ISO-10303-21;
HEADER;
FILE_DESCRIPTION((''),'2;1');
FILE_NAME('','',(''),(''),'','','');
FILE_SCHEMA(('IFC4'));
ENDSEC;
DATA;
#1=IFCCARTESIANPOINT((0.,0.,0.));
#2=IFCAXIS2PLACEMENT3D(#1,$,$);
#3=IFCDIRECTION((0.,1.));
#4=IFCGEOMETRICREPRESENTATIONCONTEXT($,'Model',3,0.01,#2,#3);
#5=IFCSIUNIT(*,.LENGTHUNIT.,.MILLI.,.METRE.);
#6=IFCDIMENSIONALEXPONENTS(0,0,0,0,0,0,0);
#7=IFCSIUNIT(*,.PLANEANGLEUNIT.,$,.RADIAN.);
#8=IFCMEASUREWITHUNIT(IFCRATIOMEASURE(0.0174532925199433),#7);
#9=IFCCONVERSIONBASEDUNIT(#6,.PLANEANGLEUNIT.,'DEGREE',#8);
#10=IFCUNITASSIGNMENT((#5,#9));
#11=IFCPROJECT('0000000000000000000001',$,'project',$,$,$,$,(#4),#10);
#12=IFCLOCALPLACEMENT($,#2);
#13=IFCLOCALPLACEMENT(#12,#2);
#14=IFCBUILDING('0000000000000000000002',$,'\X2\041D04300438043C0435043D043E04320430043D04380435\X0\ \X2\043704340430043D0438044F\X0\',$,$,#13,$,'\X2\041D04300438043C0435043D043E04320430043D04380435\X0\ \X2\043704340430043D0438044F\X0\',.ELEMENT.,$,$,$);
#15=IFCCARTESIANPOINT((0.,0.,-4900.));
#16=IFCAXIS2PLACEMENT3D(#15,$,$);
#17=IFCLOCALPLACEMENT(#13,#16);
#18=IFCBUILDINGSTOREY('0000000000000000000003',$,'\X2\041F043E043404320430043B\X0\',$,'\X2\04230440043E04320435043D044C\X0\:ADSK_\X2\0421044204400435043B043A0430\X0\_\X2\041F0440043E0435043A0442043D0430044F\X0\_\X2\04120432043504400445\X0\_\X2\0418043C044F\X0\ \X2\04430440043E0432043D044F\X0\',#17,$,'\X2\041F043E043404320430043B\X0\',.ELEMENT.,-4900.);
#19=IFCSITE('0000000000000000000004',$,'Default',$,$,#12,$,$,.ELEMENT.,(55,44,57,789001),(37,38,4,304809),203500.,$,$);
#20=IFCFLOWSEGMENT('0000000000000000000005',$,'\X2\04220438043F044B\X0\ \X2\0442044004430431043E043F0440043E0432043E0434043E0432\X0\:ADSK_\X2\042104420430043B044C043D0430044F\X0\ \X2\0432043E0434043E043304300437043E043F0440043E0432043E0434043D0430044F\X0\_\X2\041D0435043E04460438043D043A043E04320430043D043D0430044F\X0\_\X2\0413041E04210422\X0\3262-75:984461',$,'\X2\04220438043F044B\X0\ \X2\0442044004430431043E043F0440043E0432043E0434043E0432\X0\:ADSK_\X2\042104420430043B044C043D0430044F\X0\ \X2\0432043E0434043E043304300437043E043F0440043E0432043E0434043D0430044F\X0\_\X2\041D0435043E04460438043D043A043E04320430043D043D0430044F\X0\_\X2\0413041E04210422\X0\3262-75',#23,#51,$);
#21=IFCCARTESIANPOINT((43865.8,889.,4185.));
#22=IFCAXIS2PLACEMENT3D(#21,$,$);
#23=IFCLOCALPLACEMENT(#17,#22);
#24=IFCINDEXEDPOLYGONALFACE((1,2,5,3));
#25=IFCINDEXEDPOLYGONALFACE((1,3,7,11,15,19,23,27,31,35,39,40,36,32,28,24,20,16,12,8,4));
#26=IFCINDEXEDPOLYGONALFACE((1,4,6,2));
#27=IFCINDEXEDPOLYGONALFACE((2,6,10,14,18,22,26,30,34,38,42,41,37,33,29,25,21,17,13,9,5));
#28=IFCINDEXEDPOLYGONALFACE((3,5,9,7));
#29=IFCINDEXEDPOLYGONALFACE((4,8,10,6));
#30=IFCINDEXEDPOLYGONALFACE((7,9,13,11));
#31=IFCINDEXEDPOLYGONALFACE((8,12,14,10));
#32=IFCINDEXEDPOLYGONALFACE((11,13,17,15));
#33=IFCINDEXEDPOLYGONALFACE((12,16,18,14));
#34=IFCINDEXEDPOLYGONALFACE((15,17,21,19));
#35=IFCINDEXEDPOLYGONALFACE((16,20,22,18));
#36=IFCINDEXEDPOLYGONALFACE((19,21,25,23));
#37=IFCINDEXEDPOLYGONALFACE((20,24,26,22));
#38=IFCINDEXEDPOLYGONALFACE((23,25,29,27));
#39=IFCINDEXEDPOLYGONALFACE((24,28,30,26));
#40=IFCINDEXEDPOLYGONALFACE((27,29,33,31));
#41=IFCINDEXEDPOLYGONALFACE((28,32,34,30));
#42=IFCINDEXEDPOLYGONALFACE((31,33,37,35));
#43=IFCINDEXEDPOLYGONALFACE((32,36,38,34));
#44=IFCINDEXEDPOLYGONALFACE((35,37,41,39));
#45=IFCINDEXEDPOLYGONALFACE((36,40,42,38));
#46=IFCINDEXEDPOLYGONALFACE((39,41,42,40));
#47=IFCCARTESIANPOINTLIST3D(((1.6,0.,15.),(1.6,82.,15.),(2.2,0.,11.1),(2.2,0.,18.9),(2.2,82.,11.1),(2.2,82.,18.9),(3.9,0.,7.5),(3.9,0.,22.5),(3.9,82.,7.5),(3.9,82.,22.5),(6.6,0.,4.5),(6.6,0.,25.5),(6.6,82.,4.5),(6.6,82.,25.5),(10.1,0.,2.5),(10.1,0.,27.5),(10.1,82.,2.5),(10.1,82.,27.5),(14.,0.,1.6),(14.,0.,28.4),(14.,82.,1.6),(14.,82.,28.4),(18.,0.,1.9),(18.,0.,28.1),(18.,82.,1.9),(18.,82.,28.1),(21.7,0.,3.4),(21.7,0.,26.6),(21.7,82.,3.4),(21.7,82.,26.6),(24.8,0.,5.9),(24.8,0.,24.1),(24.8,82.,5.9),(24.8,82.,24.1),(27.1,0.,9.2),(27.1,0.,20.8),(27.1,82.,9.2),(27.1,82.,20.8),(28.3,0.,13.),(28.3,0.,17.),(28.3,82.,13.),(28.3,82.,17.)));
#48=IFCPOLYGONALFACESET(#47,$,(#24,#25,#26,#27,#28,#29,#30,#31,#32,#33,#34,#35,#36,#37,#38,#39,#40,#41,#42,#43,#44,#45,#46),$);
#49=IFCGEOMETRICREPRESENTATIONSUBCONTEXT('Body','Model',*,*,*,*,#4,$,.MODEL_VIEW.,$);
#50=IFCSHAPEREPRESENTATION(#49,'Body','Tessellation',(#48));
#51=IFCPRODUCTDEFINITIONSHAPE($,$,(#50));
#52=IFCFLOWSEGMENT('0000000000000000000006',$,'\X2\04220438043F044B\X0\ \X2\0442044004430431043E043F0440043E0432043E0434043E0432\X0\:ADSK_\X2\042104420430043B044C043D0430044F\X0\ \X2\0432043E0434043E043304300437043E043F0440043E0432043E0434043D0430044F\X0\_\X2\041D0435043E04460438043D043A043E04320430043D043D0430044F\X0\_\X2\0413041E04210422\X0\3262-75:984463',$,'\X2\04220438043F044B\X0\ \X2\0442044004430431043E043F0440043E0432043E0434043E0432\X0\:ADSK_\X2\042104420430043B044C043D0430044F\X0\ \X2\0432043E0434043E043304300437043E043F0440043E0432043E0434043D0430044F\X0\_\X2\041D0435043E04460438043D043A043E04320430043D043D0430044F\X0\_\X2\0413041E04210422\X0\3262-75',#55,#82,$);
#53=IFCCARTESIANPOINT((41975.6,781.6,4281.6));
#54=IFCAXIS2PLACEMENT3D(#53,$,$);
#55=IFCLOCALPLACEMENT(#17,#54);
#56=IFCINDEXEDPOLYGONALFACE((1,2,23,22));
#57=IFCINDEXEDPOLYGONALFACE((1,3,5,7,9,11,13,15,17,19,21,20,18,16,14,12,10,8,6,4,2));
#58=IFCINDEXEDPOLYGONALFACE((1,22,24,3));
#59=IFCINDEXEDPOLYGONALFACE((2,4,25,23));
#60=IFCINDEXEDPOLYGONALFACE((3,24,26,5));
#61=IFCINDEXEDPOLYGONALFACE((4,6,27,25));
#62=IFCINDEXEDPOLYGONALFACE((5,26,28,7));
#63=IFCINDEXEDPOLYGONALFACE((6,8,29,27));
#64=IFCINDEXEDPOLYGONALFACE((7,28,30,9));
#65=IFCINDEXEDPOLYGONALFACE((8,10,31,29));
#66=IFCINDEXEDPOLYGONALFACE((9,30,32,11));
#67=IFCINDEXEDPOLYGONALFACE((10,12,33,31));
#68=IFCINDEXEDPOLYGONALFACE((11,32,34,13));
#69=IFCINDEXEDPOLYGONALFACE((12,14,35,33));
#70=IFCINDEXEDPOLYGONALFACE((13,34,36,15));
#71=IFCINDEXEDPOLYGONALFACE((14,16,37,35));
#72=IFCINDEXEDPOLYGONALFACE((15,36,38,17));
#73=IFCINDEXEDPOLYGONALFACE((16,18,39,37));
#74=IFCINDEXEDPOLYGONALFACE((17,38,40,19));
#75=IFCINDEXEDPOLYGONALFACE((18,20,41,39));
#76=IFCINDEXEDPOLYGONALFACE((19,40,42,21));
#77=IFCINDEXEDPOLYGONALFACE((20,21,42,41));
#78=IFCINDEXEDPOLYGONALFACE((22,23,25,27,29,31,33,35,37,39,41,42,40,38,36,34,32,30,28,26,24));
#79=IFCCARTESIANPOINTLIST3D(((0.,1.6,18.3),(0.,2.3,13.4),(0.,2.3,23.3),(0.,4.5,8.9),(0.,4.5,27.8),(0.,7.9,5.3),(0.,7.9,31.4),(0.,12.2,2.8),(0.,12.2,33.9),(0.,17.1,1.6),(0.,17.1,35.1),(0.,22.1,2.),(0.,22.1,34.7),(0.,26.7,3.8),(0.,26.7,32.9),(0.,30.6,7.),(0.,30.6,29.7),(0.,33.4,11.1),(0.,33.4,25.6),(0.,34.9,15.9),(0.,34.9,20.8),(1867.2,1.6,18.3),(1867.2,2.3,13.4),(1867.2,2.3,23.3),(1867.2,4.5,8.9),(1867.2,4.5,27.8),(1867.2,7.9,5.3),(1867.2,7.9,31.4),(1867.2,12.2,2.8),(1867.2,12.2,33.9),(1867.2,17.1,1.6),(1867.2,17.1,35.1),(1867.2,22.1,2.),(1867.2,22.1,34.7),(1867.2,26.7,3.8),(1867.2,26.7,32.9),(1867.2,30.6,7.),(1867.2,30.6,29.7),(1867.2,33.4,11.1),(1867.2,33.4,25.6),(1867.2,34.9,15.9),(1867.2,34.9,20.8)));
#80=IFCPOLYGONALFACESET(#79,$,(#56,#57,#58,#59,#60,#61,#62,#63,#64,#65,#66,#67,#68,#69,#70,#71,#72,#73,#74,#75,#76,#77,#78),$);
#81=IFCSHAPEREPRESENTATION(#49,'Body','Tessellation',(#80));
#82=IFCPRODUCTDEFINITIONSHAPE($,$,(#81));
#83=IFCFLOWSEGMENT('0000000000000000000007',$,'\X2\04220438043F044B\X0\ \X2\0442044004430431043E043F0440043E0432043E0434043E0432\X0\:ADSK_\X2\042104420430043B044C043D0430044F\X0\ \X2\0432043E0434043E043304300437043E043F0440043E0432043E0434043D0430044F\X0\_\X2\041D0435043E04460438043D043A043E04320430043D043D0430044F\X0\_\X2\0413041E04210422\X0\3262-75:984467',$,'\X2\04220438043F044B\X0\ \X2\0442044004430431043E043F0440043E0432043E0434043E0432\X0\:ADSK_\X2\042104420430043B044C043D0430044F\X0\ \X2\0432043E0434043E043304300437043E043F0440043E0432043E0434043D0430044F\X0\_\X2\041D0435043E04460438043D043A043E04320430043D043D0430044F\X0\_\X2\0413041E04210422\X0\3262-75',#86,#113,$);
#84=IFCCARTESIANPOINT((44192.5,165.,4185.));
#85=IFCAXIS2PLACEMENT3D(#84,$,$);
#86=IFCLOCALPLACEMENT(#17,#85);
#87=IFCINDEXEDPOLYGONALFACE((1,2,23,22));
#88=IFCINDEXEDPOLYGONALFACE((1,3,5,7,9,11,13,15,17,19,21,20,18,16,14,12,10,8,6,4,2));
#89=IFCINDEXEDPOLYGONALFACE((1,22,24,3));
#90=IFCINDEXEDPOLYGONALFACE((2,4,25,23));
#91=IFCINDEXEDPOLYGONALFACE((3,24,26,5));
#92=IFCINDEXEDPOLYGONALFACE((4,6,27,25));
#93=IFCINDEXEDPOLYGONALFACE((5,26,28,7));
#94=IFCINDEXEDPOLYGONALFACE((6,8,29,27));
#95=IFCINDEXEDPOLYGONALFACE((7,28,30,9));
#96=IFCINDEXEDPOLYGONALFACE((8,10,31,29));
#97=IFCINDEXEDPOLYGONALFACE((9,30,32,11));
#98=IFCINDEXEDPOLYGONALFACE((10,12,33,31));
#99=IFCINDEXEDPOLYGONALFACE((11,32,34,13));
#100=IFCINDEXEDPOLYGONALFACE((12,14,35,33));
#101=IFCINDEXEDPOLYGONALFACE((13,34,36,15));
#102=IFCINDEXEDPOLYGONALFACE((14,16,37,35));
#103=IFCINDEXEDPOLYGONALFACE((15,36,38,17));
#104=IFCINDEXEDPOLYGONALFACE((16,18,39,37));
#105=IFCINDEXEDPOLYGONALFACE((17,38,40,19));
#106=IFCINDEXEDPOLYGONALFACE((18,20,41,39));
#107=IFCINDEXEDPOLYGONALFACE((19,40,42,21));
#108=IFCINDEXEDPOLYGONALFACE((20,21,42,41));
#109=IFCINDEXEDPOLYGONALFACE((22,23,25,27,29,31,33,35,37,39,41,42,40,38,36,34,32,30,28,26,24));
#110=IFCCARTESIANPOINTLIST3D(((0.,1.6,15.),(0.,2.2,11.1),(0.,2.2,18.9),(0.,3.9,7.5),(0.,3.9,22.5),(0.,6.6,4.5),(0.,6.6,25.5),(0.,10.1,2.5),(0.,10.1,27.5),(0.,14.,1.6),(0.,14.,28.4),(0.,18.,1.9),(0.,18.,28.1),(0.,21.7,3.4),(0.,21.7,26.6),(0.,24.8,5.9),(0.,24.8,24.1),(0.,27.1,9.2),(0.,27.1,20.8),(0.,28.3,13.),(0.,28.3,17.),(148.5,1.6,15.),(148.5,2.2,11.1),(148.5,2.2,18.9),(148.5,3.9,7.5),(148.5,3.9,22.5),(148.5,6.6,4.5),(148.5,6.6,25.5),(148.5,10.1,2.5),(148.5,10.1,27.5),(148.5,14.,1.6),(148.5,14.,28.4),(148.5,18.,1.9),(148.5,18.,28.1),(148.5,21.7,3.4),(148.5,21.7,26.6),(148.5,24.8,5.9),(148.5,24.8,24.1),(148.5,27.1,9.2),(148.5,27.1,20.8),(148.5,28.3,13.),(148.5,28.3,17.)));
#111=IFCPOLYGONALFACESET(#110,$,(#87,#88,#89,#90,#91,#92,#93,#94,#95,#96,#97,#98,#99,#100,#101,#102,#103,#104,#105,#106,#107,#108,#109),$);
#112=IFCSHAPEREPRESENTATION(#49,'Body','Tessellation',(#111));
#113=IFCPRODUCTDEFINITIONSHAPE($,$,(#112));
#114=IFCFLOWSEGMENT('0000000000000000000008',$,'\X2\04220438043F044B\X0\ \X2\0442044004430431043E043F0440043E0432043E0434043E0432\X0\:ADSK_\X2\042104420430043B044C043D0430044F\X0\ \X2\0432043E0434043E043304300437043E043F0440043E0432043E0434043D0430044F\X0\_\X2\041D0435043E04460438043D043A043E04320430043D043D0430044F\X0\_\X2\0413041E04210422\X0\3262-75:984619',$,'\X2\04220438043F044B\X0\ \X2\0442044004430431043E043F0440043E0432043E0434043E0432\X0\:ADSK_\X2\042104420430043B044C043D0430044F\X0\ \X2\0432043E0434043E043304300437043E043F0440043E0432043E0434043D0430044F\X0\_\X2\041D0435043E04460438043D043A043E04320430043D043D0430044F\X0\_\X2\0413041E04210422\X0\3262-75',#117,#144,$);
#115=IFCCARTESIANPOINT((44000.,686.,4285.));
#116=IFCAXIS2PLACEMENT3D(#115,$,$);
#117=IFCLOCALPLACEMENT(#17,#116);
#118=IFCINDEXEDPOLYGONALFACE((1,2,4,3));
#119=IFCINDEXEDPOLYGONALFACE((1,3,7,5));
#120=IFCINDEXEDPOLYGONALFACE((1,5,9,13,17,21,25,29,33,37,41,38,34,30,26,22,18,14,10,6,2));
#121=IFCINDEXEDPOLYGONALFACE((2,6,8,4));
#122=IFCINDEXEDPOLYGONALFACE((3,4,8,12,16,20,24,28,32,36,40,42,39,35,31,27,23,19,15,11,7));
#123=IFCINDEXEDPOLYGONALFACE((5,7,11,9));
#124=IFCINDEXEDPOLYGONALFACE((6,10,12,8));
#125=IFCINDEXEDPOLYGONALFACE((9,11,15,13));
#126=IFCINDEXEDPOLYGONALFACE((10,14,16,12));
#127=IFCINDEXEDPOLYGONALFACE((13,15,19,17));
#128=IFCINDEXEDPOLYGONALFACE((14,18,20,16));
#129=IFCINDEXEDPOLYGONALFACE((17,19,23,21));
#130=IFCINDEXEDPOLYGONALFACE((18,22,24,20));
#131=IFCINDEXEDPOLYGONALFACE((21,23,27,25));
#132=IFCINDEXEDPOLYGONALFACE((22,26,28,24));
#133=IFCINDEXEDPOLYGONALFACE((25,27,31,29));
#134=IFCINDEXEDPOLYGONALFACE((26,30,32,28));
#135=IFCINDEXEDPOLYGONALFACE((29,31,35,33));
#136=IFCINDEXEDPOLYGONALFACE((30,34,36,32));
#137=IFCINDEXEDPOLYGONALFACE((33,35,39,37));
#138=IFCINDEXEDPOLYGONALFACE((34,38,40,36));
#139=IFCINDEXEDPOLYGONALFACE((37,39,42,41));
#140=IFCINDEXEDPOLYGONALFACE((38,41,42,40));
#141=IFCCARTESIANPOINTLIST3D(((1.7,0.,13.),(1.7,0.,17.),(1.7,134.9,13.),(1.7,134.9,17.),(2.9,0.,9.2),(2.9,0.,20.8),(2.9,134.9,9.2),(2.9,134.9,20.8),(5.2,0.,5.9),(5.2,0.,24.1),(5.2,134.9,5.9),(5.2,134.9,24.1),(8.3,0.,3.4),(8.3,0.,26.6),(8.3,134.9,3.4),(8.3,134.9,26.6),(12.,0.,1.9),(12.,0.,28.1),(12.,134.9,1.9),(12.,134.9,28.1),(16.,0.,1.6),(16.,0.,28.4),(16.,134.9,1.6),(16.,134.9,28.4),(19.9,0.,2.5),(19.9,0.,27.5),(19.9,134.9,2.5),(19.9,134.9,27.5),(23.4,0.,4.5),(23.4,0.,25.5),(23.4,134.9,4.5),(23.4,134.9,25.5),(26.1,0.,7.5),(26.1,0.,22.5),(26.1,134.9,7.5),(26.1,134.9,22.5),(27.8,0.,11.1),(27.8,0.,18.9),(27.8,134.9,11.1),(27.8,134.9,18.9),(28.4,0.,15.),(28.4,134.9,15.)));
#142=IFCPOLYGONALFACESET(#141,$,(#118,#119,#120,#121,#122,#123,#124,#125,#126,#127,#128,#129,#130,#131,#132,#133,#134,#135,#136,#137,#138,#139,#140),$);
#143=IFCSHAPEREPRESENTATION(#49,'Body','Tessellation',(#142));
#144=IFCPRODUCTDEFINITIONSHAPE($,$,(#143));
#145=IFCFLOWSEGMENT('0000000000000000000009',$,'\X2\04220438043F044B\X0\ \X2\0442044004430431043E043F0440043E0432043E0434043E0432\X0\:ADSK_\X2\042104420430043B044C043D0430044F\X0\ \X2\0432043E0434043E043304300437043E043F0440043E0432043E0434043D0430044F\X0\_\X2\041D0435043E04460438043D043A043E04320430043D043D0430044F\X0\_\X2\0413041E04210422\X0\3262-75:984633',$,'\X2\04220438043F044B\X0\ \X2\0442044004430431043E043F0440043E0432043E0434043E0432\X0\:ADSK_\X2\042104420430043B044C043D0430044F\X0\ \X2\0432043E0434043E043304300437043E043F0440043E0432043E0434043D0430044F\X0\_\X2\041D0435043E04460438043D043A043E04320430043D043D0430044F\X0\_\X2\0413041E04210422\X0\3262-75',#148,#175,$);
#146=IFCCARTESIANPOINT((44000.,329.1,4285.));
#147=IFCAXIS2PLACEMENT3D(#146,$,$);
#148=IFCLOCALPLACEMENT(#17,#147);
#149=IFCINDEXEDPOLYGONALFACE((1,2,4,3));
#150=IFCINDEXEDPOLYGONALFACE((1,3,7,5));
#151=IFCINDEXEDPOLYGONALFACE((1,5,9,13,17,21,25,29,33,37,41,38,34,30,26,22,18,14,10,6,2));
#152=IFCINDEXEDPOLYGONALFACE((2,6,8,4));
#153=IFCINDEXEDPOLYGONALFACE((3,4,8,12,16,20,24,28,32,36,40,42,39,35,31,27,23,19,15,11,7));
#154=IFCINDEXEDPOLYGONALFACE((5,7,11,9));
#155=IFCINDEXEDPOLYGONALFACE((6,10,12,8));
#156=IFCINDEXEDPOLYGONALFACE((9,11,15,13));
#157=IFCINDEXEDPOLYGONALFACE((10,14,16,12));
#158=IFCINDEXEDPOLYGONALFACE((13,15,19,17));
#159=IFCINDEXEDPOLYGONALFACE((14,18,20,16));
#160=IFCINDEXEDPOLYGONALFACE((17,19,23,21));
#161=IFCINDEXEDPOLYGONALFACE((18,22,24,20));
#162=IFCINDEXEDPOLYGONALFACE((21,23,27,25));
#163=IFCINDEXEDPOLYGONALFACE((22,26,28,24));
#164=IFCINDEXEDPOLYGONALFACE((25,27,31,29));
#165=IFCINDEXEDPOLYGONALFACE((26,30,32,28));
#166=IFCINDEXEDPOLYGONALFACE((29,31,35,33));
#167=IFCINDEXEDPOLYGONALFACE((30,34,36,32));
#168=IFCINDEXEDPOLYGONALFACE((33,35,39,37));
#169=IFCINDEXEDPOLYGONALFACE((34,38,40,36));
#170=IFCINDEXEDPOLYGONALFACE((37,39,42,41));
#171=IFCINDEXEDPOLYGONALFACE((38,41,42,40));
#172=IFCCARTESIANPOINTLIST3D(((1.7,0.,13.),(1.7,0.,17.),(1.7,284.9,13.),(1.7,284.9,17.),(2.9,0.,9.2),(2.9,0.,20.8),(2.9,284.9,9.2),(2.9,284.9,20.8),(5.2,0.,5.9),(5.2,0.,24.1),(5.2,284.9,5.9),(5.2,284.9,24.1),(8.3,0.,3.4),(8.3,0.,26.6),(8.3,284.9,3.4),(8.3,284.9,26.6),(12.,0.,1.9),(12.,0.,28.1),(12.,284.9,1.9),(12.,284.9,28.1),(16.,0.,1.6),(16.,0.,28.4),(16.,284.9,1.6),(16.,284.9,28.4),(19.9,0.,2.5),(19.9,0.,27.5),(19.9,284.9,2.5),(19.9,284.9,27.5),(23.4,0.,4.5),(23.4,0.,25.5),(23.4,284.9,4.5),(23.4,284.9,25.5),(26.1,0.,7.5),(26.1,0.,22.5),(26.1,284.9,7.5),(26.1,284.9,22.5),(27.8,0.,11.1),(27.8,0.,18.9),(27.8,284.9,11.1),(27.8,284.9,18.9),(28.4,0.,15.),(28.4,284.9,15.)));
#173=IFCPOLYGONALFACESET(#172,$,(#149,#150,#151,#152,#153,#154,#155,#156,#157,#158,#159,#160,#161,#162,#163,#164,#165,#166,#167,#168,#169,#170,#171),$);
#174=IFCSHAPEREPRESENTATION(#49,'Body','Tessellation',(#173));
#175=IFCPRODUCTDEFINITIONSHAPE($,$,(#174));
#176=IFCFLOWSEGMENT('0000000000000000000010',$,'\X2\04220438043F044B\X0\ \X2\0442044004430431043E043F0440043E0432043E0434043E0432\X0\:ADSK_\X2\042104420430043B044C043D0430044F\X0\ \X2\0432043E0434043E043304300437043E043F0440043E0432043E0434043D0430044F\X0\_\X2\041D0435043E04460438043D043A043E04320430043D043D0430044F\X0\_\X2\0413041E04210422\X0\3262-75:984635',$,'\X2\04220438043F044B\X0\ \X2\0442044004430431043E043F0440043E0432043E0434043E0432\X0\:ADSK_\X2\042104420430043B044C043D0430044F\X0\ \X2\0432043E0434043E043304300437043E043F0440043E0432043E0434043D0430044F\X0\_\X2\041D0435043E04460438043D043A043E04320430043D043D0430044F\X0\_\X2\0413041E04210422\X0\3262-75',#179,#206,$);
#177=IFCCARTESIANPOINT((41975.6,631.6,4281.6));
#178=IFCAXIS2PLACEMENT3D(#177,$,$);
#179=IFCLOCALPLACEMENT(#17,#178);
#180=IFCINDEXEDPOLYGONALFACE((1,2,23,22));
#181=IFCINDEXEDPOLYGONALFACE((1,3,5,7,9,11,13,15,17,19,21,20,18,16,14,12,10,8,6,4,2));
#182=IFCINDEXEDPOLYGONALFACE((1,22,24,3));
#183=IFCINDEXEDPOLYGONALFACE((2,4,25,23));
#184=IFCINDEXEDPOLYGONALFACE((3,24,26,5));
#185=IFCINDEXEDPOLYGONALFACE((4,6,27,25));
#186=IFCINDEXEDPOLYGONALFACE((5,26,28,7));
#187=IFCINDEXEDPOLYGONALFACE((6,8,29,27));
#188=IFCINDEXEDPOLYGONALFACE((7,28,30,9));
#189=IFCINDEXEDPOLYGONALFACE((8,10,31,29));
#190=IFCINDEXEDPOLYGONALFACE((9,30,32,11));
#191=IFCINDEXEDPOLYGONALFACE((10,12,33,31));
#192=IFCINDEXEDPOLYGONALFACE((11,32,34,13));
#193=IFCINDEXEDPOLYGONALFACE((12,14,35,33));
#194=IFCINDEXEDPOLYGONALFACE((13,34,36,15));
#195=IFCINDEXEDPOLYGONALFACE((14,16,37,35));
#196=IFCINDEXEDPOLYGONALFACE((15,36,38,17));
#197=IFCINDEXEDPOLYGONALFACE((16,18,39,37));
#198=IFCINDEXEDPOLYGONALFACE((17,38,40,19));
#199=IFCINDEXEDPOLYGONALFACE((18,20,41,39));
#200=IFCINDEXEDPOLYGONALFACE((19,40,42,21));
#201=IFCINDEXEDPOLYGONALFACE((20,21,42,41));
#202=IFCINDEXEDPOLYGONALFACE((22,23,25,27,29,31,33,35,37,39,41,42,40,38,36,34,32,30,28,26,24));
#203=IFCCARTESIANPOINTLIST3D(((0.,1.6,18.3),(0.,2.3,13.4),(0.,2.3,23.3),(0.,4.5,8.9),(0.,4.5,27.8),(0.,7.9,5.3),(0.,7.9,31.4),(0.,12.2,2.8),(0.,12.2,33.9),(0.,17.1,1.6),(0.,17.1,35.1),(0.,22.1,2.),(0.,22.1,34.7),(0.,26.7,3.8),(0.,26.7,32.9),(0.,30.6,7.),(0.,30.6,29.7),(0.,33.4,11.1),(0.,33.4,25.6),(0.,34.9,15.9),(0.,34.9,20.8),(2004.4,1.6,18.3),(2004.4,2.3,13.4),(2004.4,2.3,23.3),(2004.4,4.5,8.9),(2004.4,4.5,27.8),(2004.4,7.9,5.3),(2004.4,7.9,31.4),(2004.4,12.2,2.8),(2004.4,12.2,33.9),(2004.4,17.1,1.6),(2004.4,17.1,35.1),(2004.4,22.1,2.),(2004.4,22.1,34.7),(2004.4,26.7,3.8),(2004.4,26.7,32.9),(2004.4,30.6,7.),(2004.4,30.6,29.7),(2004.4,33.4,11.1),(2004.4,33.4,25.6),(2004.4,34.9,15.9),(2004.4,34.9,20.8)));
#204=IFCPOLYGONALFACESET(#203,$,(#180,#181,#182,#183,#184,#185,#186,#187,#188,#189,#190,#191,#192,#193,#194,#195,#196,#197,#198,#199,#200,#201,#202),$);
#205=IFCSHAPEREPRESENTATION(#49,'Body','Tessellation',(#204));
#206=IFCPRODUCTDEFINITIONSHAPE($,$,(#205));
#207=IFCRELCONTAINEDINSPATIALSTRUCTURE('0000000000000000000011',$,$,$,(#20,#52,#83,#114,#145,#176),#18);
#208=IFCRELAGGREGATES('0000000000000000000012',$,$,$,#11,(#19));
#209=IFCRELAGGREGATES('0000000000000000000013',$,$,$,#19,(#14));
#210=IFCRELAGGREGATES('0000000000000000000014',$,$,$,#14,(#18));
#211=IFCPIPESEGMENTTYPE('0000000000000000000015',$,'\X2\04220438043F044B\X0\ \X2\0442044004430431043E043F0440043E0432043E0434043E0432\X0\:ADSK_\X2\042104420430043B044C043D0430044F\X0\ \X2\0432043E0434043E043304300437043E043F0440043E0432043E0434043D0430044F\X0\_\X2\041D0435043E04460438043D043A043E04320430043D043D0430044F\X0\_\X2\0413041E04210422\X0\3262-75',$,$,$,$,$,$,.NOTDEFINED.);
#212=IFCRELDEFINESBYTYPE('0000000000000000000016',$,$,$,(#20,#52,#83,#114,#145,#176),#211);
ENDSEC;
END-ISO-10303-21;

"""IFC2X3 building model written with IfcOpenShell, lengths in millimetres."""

from ifc_helpers import new_model, entity, si_unit, converted_unit, direction, frame, origin, origin_2d_with_axis, place, context, subcontext, project, spatial, circle, extrude, type_object, element, save


model = new_model("IFC2X3")

# Units and contexts
model_context = context("Model", 3, precision=0.01, world=origin(), true_north=direction((0.0, 1.0)))
body_context = subcontext(model_context, "Body", "Model", "MODEL_VIEW")
ifc_project = project(units=[si_unit("LENGTHUNIT", "METRE", prefix="MILLI"), converted_unit("PLANEANGLEUNIT", "DEGREE", entity("IfcRatioMeasure", 0.0174532925199433), si_unit("PLANEANGLEUNIT", "RADIAN"), dimensions=[0, 0, 0, 0, 0, 0, 0])], contexts=[model_context])

# Site, building, storey
site_placement = place(None, origin())
site = spatial("IfcSite", under=ifc_project, at=site_placement, Name="Default", CompositionType="ELEMENT", RefLatitude=(55, 44, 57, 789001), RefLongitude=(37, 38, 4, 304809), RefElevation=203500.0)
building_placement = place(site_placement, origin())
building = spatial("IfcBuilding", under=site, at=building_placement, Name="Наименование здания", LongName="Наименование здания", CompositionType="ELEMENT")
storey_placement = place(building_placement, frame((0.0, 0.0, -4900.0)))
storey = spatial("IfcBuildingStorey", under=building, at=storey_placement, Name="Подвал", ObjectType="Уровень:ADSK_Стрелка_Проектная_Вверх_Имя уровня", LongName="Подвал", CompositionType="ELEMENT", Elevation=-4900.0)

# Flow segments
pipe_segment_type = type_object("IfcPipeSegmentType", Name="Типы трубопроводов:ADSK_Стальная водогазопроводная_Неоцинкованная_ГОСТ3262-75", PredefinedType="NOTDEFINED")
flow_segment_1_placement = place(storey_placement, frame((43865.8, 889.0, 4185.0)))
element("IfcFlowSegment", 1, at=flow_segment_1_placement, inside=storey, type_object=pipe_segment_type, Name="Типы трубопроводов:ADSK_Стальная водогазопроводная_Неоцинкованная_ГОСТ3262-75:984461", ObjectType="Типы трубопроводов:ADSK_Стальная водогазопроводная_Неоцинкованная_ГОСТ3262-75", context=body_context, shape_type="SweptSolid", body=[
    extrude(circle(Radius=13.4, at=origin_2d_with_axis()), frame((15.0, 0.0, 15.0), z_axis=(0.0, 1.0, 0.0), x_axis=(-1.0, 0.0, 0.0)), (0.0, 0.0, 1.0), 82.0),
])
flow_segment_2_placement = place(storey_placement, frame((41975.6, 781.6, 4281.6)))
element("IfcFlowSegment", 2, at=flow_segment_2_placement, inside=storey, type_object=pipe_segment_type, Name="Типы трубопроводов:ADSK_Стальная водогазопроводная_Неоцинкованная_ГОСТ3262-75:984463", ObjectType="Типы трубопроводов:ADSK_Стальная водогазопроводная_Неоцинкованная_ГОСТ3262-75", context=body_context, shape_type="SweptSolid", body=[
    extrude(circle(Radius=16.8, at=origin_2d_with_axis()), frame((0.0, 18.4, 18.4), z_axis=(1.0, 0.0, 0.0), x_axis=(0.0, -1.0, 0.0)), (0.0, 0.0, 1.0), 1867.2),
])
flow_segment_3_placement = place(storey_placement, frame((44192.5, 165.0, 4185.0)))
element("IfcFlowSegment", 3, at=flow_segment_3_placement, inside=storey, type_object=pipe_segment_type, Name="Типы трубопроводов:ADSK_Стальная водогазопроводная_Неоцинкованная_ГОСТ3262-75:984467", ObjectType="Типы трубопроводов:ADSK_Стальная водогазопроводная_Неоцинкованная_ГОСТ3262-75", context=body_context, shape_type="SweptSolid", body=[
    extrude(circle(Radius=13.4, at=origin_2d_with_axis()), frame((0.0, 15.0, 15.0), z_axis=(1.0, 0.0, 0.0), x_axis=(0.0, -1.0, 0.0)), (0.0, 0.0, 1.0), 148.5),
])
flow_segment_4_placement = place(storey_placement, frame((44000.0, 686.0, 4285.0)))
element("IfcFlowSegment", 4, at=flow_segment_4_placement, inside=storey, type_object=pipe_segment_type, Name="Типы трубопроводов:ADSK_Стальная водогазопроводная_Неоцинкованная_ГОСТ3262-75:984619", ObjectType="Типы трубопроводов:ADSK_Стальная водогазопроводная_Неоцинкованная_ГОСТ3262-75", context=body_context, shape_type="SweptSolid", body=[
    extrude(circle(Radius=13.4, at=origin_2d_with_axis()), frame((15.0, 0.0, 15.0), z_axis=(0.0, 1.0, 0.0), x_axis=(1.0, 0.0, 0.0)), (0.0, 0.0, 1.0), 134.9),
])
flow_segment_5_placement = place(storey_placement, frame((44000.0, 329.1, 4285.0)))
element("IfcFlowSegment", 5, at=flow_segment_5_placement, inside=storey, type_object=pipe_segment_type, Name="Типы трубопроводов:ADSK_Стальная водогазопроводная_Неоцинкованная_ГОСТ3262-75:984633", ObjectType="Типы трубопроводов:ADSK_Стальная водогазопроводная_Неоцинкованная_ГОСТ3262-75", context=body_context, shape_type="SweptSolid", body=[
    extrude(circle(Radius=13.4, at=origin_2d_with_axis()), frame((15.0, 0.0, 15.0), z_axis=(0.0, 1.0, 0.0), x_axis=(1.0, 0.0, 0.0)), (0.0, 0.0, 1.0), 284.9),
])
flow_segment_6_placement = place(storey_placement, frame((41975.6, 631.6, 4281.6)))
element("IfcFlowSegment", 6, at=flow_segment_6_placement, inside=storey, type_object=pipe_segment_type, Name="Типы трубопроводов:ADSK_Стальная водогазопроводная_Неоцинкованная_ГОСТ3262-75:984635", ObjectType="Типы трубопроводов:ADSK_Стальная водогазопроводная_Неоцинкованная_ГОСТ3262-75", context=body_context, shape_type="SweptSolid", body=[
    extrude(circle(Radius=16.8, at=origin_2d_with_axis()), frame((0.0, 18.4, 18.4), z_axis=(1.0, 0.0, 0.0), x_axis=(0.0, -1.0, 0.0)), (0.0, 0.0, 1.0), 2004.4),
])

save(model, "model.ifc")
